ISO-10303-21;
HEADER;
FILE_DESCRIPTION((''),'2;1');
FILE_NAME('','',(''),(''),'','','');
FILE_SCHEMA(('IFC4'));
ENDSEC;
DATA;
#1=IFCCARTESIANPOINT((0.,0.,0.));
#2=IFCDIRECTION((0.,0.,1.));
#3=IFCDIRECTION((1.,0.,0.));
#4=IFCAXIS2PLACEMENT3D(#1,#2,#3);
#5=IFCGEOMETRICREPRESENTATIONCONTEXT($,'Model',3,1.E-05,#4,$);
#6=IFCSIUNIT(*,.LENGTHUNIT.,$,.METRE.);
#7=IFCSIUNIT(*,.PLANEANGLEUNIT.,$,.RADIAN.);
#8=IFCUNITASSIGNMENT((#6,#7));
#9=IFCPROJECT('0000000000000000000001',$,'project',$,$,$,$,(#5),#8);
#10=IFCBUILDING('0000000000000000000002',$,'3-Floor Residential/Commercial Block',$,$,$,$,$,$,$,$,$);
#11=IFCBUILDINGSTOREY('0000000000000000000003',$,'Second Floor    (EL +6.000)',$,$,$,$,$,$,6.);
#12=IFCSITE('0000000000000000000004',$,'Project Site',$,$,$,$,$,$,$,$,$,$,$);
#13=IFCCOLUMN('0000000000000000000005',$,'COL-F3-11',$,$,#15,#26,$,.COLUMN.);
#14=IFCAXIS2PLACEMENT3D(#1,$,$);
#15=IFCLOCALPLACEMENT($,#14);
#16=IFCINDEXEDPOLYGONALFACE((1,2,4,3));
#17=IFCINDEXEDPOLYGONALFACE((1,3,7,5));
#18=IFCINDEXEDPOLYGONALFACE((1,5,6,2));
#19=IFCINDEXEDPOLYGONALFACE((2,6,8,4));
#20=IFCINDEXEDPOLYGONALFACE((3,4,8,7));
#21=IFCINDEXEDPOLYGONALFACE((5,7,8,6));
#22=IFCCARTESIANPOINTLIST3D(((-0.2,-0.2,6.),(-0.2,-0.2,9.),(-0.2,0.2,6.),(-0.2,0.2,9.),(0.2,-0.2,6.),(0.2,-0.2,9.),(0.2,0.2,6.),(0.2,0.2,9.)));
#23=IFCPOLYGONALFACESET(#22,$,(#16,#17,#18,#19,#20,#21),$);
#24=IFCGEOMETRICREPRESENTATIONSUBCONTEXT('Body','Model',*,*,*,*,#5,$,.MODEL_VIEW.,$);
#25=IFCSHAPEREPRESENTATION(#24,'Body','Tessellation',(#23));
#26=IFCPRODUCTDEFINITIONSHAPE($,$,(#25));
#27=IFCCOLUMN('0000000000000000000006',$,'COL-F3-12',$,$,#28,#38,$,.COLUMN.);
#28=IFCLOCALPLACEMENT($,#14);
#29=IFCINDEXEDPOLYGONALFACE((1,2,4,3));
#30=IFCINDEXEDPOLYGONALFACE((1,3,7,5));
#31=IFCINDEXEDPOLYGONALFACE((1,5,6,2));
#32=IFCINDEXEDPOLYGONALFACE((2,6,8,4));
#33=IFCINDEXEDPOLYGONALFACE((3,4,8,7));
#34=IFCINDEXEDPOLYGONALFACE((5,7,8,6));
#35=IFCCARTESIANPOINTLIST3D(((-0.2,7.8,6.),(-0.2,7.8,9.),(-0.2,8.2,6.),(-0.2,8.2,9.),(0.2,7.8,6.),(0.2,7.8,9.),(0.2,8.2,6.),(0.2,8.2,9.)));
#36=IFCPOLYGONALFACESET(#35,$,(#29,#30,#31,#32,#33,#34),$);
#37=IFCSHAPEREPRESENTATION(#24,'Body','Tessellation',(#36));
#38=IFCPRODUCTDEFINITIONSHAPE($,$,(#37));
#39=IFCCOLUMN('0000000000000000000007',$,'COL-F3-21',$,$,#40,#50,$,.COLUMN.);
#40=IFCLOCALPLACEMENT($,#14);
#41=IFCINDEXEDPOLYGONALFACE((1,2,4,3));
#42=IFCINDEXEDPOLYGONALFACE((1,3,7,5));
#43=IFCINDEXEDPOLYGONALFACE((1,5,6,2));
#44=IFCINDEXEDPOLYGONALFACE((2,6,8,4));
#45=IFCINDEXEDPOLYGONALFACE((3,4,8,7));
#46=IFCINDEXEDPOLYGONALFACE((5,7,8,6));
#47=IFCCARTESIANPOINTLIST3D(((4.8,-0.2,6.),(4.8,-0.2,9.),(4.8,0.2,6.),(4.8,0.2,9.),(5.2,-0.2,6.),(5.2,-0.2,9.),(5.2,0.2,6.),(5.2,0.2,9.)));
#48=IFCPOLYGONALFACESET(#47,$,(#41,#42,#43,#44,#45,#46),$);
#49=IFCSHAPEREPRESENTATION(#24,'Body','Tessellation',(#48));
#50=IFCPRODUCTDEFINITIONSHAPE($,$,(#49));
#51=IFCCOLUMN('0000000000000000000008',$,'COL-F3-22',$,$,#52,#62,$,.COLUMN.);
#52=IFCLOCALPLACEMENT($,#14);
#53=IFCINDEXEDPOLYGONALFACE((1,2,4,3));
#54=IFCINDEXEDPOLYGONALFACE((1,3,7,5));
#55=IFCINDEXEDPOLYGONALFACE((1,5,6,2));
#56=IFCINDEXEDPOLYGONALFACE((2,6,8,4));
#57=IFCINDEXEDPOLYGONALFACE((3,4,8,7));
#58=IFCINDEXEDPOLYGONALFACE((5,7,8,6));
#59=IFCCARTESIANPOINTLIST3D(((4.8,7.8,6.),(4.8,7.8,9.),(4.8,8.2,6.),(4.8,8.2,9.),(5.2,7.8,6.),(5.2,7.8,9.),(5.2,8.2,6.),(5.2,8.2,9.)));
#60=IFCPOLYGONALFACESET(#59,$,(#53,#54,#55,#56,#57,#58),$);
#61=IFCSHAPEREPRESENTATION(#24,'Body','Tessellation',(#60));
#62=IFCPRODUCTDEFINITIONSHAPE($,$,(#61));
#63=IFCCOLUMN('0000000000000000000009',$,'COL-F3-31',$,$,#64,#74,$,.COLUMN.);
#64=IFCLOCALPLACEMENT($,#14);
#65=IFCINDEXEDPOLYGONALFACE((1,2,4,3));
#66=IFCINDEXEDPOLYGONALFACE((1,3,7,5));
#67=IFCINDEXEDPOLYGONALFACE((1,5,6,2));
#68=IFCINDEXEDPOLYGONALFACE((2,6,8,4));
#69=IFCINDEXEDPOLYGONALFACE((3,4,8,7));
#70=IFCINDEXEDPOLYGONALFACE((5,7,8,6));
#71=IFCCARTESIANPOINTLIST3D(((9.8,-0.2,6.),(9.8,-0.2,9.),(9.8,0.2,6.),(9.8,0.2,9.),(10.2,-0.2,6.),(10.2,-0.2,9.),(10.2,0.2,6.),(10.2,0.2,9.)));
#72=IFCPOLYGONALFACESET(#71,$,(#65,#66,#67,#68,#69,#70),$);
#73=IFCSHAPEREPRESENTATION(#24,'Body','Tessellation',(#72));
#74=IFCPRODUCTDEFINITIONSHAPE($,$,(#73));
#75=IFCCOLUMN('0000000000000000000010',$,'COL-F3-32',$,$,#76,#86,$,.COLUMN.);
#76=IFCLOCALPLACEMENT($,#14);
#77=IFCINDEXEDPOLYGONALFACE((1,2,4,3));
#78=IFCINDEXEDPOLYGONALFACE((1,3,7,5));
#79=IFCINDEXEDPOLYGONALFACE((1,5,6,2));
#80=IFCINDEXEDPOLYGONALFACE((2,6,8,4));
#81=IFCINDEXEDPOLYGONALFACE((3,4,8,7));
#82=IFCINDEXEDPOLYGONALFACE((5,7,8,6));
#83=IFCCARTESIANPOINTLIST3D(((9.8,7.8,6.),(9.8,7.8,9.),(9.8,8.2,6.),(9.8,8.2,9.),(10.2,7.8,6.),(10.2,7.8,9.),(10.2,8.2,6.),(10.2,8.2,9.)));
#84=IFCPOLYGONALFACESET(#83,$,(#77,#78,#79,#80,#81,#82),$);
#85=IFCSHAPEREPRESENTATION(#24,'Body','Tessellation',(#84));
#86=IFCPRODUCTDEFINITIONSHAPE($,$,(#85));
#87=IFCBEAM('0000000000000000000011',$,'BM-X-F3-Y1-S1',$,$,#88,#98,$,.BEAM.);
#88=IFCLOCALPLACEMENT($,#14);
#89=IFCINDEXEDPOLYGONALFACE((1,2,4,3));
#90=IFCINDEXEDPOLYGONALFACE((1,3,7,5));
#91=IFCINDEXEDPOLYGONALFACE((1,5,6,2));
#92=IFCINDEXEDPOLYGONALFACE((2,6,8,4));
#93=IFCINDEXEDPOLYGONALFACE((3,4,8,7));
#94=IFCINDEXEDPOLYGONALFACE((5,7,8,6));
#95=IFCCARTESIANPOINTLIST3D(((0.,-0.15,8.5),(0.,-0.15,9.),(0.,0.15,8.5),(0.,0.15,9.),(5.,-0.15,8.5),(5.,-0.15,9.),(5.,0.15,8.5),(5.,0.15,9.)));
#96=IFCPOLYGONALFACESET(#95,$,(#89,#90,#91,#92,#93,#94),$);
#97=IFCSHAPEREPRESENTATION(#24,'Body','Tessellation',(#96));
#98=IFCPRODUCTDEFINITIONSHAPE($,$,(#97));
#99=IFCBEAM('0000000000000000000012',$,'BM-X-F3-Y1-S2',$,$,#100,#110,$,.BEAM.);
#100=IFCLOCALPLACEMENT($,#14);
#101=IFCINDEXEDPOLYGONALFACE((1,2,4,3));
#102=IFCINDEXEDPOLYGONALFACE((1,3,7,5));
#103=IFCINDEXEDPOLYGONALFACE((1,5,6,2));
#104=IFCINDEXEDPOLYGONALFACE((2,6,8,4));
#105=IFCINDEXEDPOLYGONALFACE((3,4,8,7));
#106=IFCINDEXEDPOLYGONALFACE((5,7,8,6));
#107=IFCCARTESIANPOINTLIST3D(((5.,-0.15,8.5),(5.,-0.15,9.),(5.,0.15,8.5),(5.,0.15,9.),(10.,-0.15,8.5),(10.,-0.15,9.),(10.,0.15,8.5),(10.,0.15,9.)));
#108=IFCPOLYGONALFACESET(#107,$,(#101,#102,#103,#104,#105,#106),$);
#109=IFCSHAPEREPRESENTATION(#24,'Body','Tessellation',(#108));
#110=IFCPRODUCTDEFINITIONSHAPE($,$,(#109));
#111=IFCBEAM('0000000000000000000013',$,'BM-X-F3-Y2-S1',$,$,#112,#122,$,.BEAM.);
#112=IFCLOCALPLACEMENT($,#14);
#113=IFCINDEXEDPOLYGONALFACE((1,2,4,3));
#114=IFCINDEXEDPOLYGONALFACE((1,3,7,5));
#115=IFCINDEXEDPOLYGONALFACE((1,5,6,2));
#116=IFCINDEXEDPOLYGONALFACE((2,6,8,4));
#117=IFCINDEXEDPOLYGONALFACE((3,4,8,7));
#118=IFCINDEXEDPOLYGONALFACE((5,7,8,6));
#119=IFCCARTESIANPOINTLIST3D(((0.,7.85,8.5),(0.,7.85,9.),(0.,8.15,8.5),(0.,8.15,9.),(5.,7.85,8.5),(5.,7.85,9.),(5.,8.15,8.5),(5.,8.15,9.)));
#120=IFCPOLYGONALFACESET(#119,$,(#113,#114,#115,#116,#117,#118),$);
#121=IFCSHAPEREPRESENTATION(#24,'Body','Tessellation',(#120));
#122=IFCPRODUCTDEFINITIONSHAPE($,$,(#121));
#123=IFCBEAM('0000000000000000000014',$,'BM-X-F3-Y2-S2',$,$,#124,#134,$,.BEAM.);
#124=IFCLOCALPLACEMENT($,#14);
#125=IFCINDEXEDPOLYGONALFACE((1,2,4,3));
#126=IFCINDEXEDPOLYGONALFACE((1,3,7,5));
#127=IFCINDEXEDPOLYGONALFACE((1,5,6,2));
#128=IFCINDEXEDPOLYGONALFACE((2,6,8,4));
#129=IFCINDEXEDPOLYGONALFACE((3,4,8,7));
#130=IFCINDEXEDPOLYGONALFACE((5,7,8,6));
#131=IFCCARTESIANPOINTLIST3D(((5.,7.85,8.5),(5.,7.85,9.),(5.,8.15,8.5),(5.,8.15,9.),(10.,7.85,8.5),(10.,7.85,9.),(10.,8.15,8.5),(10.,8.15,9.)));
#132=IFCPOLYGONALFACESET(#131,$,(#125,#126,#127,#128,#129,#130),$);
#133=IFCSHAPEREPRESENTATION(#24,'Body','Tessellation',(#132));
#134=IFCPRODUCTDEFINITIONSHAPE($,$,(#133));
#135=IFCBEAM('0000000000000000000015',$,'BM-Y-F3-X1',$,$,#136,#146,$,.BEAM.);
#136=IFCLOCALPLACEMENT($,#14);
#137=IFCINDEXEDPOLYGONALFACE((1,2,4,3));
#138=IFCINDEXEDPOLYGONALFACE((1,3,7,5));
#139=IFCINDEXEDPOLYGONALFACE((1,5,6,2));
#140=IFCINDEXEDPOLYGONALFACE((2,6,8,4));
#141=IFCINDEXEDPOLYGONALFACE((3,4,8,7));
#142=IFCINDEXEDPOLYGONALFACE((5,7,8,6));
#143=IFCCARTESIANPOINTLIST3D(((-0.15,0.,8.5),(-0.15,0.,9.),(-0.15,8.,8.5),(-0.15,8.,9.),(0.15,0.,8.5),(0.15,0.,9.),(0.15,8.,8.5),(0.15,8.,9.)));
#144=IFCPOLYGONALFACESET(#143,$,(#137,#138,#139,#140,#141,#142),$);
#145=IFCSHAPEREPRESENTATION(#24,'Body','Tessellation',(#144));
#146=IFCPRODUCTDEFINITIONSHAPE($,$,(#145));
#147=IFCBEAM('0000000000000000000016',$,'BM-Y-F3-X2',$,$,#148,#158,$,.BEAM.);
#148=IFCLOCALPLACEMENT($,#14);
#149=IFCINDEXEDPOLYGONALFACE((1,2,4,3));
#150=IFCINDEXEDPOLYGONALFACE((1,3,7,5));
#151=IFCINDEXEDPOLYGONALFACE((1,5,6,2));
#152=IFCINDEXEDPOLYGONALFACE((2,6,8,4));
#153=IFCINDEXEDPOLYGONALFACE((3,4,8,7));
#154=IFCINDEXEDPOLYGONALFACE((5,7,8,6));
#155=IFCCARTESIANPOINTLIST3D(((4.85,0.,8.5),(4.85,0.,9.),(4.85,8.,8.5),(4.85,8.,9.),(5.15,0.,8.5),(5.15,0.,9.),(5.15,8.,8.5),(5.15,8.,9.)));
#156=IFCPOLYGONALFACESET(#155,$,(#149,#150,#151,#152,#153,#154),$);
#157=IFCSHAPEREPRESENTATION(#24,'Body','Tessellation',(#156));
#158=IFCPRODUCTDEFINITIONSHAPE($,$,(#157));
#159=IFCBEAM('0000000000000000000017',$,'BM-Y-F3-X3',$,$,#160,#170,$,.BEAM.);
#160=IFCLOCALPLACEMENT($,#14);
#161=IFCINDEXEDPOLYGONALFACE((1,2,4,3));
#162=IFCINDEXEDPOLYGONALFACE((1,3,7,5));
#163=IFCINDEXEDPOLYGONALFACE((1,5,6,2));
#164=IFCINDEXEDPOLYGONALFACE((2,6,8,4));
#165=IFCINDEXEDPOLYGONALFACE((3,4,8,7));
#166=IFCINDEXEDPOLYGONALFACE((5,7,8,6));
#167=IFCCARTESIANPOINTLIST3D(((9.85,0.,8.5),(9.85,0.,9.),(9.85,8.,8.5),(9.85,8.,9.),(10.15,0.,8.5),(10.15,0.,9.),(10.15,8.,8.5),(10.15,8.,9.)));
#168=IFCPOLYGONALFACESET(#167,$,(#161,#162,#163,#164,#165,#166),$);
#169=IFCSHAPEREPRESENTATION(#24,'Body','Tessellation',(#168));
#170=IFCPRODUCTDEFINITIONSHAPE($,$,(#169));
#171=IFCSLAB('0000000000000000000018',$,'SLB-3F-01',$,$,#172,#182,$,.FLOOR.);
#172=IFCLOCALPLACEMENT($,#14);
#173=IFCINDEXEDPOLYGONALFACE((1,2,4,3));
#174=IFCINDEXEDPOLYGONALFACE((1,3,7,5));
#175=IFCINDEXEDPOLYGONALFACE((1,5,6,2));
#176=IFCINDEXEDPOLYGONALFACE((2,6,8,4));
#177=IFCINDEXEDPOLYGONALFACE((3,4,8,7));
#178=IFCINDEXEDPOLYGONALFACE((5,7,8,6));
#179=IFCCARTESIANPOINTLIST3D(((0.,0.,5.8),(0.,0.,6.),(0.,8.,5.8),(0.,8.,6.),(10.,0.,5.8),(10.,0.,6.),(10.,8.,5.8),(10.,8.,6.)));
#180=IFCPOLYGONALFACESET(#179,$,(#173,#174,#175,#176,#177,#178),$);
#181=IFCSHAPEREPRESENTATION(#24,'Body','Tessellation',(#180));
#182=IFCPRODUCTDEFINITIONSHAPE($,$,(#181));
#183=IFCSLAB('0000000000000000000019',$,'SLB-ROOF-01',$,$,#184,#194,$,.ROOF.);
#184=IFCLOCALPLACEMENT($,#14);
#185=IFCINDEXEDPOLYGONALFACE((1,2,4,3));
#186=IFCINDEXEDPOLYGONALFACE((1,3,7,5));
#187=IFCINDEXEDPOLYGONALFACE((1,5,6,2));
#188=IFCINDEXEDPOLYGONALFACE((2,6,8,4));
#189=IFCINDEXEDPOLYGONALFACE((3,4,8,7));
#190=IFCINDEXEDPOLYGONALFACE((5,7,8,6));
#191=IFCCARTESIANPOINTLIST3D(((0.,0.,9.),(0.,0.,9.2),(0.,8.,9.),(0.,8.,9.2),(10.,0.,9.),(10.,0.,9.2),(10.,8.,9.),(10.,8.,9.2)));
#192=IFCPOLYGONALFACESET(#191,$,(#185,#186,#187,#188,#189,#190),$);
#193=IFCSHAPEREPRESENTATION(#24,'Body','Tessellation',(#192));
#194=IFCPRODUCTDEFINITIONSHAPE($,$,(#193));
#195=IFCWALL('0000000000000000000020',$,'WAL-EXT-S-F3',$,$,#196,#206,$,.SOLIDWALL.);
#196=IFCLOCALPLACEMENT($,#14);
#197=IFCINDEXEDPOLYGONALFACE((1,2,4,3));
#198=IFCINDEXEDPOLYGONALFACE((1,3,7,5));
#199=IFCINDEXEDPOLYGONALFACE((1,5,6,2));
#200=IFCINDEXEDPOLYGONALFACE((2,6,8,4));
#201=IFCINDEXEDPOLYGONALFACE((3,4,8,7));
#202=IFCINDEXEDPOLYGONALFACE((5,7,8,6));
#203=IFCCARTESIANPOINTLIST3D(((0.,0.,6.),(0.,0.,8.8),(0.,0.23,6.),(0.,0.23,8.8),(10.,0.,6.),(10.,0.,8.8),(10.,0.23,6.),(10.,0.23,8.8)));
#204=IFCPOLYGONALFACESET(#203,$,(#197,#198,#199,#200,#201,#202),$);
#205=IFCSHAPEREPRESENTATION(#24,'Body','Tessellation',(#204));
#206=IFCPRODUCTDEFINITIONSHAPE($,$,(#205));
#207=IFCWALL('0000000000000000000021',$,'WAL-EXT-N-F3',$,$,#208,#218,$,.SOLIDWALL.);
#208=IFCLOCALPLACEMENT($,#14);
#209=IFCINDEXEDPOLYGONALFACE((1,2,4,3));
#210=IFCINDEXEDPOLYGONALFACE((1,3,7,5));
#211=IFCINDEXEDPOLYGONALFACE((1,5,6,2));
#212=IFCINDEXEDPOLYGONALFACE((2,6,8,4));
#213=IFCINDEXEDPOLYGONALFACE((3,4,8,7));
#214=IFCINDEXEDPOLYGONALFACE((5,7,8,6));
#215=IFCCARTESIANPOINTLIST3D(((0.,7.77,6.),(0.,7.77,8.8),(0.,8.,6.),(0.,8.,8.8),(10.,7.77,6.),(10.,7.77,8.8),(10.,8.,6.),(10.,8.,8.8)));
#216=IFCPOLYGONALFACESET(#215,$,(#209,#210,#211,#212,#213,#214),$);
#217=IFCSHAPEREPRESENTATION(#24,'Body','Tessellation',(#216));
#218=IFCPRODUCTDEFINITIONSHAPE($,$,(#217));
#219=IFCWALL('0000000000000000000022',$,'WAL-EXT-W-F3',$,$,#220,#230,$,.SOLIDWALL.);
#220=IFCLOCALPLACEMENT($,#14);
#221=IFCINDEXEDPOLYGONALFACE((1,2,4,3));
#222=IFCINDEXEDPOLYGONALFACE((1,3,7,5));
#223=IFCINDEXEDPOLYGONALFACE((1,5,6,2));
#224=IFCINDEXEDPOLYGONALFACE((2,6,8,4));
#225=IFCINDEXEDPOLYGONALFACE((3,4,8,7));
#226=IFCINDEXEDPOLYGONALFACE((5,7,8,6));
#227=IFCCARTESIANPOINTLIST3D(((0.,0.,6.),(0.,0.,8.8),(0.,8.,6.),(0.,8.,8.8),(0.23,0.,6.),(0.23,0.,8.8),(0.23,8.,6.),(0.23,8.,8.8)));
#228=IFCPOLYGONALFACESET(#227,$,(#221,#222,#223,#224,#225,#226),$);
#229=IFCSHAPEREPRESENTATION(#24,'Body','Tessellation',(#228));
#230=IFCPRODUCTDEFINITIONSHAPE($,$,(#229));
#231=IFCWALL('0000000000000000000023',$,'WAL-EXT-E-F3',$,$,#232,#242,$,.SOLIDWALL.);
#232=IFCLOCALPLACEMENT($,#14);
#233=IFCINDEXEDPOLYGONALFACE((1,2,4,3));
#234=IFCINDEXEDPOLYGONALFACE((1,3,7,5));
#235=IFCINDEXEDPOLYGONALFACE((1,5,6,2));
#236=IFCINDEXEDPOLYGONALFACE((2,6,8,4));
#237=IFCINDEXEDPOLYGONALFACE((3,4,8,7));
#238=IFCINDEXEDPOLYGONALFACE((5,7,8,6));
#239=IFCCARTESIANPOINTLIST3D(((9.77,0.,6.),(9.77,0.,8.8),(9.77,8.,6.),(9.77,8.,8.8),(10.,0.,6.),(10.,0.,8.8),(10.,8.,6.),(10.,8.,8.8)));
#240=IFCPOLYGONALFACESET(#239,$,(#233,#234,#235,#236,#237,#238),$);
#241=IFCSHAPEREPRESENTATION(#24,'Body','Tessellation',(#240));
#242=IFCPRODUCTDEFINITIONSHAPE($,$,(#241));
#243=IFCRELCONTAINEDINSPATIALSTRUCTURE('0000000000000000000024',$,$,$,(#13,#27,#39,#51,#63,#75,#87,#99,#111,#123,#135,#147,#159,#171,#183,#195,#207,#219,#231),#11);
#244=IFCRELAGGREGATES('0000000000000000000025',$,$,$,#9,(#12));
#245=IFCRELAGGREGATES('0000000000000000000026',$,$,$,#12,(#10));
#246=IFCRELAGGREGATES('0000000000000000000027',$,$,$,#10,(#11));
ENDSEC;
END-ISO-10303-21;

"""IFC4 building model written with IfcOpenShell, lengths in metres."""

from ifc_helpers import new_model, si_unit, frame, frame_2d, origin_with_axes, place, context, subcontext, project, spatial, rectangle, extrude, element, save


model = new_model("IFC4")

# Units and contexts
model_context = context("Model", 3, precision=1e-05, world=origin_with_axes())
body_context = subcontext(model_context, "Body", "Model", "MODEL_VIEW")
ifc_project = project(units=[si_unit("LENGTHUNIT", "METRE"), si_unit("PLANEANGLEUNIT", "RADIAN")], contexts=[model_context])

# Site, building, storey
site = spatial("IfcSite", under=ifc_project, Name="Project Site")
building = spatial("IfcBuilding", under=site, Name="3-Floor Residential/Commercial Block")
storey = spatial("IfcBuildingStorey", under=building, Name="Second Floor    (EL +6.000)", Elevation=6.0)

# Columns
for number, where, z_axis, x_axis, name in (
    (1, (-0.2, -0.2, 6.0), (0.0, 0.0, 1.0), (1.0, 0.0, 0.0), "COL-F3-11"),
    (2, (-0.2, 7.8, 6.0), (0.0, 0.0, 1.0), (1.0, 0.0, 0.0), "COL-F3-12"),
    (3, (4.8, -0.2, 6.0), (0.0, 0.0, 1.0), (1.0, 0.0, 0.0), "COL-F3-21"),
    (4, (4.8, 7.8, 6.0), (0.0, 0.0, 1.0), (1.0, 0.0, 0.0), "COL-F3-22"),
    (5, (9.8, -0.2, 6.0), (0.0, 0.0, 1.0), (1.0, 0.0, 0.0), "COL-F3-31"),
    (6, (9.8, 7.8, 6.0), (0.0, 0.0, 1.0), (1.0, 0.0, 0.0), "COL-F3-32"),
):
    element("IfcColumn", number, at=place(None, frame(where, z_axis=z_axis, x_axis=x_axis)), inside=storey, Name=name, PredefinedType="COLUMN", context=body_context, shape_type="SweptSolid", body=[
        extrude(rectangle(XDim=0.4, YDim=0.4, at=frame_2d((0.2, 0.2))), origin_with_axes(), (0.0, 0.0, 1.0), 3.0),
    ])

# Beams
for number, where, z_axis, x_axis, name in (
    (7, (0.0, -0.15, 8.5), (0.0, 0.0, 1.0), (1.0, 0.0, 0.0), "BM-X-F3-Y1-S1"),
    (8, (5.0, -0.15, 8.5), (0.0, 0.0, 1.0), (1.0, 0.0, 0.0), "BM-X-F3-Y1-S2"),
    (9, (0.0, 7.85, 8.5), (0.0, 0.0, 1.0), (1.0, 0.0, 0.0), "BM-X-F3-Y2-S1"),
    (10, (5.0, 7.85, 8.5), (0.0, 0.0, 1.0), (1.0, 0.0, 0.0), "BM-X-F3-Y2-S2"),
):
    element("IfcBeam", number, at=place(None, frame(where, z_axis=z_axis, x_axis=x_axis)), inside=storey, Name=name, PredefinedType="BEAM", context=body_context, shape_type="SweptSolid", body=[
        extrude(rectangle(XDim=5.0, YDim=0.3, at=frame_2d((2.5, 0.15))), origin_with_axes(), (0.0, 0.0, 1.0), 0.5),
    ])
for number, where, z_axis, x_axis, name in (
    (11, (-0.15, 0.0, 8.5), (0.0, 0.0, 1.0), (1.0, 0.0, 0.0), "BM-Y-F3-X1"),
    (12, (4.85, 0.0, 8.5), (0.0, 0.0, 1.0), (1.0, 0.0, 0.0), "BM-Y-F3-X2"),
    (13, (9.85, 0.0, 8.5), (0.0, 0.0, 1.0), (1.0, 0.0, 0.0), "BM-Y-F3-X3"),
):
    element("IfcBeam", number, at=place(None, frame(where, z_axis=z_axis, x_axis=x_axis)), inside=storey, Name=name, PredefinedType="BEAM", context=body_context, shape_type="SweptSolid", body=[
        extrude(rectangle(XDim=0.3, YDim=8.0, at=frame_2d((0.15, 4.0))), origin_with_axes(), (0.0, 0.0, 1.0), 0.5),
    ])

# Slabs
slab_1_placement = place(None, frame((0.0, 0.0, 5.8), z_axis=(0.0, 0.0, 1.0), x_axis=(1.0, 0.0, 0.0)))
element("IfcSlab", 14, at=slab_1_placement, inside=storey, Name="SLB-3F-01", PredefinedType="FLOOR", context=body_context, shape_type="SweptSolid", body=[
    extrude(rectangle(XDim=10.0, YDim=8.0, at=frame_2d((5.0, 4.0))), origin_with_axes(), (0.0, 0.0, 1.0), 0.2),
])
slab_2_placement = place(None, frame((0.0, 0.0, 9.0), z_axis=(0.0, 0.0, 1.0), x_axis=(1.0, 0.0, 0.0)))
element("IfcSlab", 15, at=slab_2_placement, inside=storey, Name="SLB-ROOF-01", PredefinedType="ROOF", context=body_context, shape_type="SweptSolid", body=[
    extrude(rectangle(XDim=10.0, YDim=8.0, at=frame_2d((5.0, 4.0))), origin_with_axes(), (0.0, 0.0, 1.0), 0.2),
])

# Walls
for number, where, z_axis, x_axis, name in (
    (16, (0.0, 0.0, 6.0), (0.0, 0.0, 1.0), (1.0, 0.0, 0.0), "WAL-EXT-S-F3"),
    (17, (0.0, 7.77, 6.0), (0.0, 0.0, 1.0), (1.0, 0.0, 0.0), "WAL-EXT-N-F3"),
):
    element("IfcWall", number, at=place(None, frame(where, z_axis=z_axis, x_axis=x_axis)), inside=storey, Name=name, PredefinedType="SOLIDWALL", context=body_context, shape_type="SweptSolid", body=[
        extrude(rectangle(XDim=10.0, YDim=0.23, at=frame_2d((5.0, 0.115))), origin_with_axes(), (0.0, 0.0, 1.0), 2.8),
    ])
for number, where, z_axis, x_axis, name in (
    (18, (0.0, 0.0, 6.0), (0.0, 0.0, 1.0), (1.0, 0.0, 0.0), "WAL-EXT-W-F3"),
    (19, (9.77, 0.0, 6.0), (0.0, 0.0, 1.0), (1.0, 0.0, 0.0), "WAL-EXT-E-F3"),
):
    element("IfcWall", number, at=place(None, frame(where, z_axis=z_axis, x_axis=x_axis)), inside=storey, Name=name, PredefinedType="SOLIDWALL", context=body_context, shape_type="SweptSolid", body=[
        extrude(rectangle(XDim=0.23, YDim=8.0, at=frame_2d((0.115, 4.0))), origin_with_axes(), (0.0, 0.0, 1.0), 2.8),
    ])

save(model, "model.ifc")
